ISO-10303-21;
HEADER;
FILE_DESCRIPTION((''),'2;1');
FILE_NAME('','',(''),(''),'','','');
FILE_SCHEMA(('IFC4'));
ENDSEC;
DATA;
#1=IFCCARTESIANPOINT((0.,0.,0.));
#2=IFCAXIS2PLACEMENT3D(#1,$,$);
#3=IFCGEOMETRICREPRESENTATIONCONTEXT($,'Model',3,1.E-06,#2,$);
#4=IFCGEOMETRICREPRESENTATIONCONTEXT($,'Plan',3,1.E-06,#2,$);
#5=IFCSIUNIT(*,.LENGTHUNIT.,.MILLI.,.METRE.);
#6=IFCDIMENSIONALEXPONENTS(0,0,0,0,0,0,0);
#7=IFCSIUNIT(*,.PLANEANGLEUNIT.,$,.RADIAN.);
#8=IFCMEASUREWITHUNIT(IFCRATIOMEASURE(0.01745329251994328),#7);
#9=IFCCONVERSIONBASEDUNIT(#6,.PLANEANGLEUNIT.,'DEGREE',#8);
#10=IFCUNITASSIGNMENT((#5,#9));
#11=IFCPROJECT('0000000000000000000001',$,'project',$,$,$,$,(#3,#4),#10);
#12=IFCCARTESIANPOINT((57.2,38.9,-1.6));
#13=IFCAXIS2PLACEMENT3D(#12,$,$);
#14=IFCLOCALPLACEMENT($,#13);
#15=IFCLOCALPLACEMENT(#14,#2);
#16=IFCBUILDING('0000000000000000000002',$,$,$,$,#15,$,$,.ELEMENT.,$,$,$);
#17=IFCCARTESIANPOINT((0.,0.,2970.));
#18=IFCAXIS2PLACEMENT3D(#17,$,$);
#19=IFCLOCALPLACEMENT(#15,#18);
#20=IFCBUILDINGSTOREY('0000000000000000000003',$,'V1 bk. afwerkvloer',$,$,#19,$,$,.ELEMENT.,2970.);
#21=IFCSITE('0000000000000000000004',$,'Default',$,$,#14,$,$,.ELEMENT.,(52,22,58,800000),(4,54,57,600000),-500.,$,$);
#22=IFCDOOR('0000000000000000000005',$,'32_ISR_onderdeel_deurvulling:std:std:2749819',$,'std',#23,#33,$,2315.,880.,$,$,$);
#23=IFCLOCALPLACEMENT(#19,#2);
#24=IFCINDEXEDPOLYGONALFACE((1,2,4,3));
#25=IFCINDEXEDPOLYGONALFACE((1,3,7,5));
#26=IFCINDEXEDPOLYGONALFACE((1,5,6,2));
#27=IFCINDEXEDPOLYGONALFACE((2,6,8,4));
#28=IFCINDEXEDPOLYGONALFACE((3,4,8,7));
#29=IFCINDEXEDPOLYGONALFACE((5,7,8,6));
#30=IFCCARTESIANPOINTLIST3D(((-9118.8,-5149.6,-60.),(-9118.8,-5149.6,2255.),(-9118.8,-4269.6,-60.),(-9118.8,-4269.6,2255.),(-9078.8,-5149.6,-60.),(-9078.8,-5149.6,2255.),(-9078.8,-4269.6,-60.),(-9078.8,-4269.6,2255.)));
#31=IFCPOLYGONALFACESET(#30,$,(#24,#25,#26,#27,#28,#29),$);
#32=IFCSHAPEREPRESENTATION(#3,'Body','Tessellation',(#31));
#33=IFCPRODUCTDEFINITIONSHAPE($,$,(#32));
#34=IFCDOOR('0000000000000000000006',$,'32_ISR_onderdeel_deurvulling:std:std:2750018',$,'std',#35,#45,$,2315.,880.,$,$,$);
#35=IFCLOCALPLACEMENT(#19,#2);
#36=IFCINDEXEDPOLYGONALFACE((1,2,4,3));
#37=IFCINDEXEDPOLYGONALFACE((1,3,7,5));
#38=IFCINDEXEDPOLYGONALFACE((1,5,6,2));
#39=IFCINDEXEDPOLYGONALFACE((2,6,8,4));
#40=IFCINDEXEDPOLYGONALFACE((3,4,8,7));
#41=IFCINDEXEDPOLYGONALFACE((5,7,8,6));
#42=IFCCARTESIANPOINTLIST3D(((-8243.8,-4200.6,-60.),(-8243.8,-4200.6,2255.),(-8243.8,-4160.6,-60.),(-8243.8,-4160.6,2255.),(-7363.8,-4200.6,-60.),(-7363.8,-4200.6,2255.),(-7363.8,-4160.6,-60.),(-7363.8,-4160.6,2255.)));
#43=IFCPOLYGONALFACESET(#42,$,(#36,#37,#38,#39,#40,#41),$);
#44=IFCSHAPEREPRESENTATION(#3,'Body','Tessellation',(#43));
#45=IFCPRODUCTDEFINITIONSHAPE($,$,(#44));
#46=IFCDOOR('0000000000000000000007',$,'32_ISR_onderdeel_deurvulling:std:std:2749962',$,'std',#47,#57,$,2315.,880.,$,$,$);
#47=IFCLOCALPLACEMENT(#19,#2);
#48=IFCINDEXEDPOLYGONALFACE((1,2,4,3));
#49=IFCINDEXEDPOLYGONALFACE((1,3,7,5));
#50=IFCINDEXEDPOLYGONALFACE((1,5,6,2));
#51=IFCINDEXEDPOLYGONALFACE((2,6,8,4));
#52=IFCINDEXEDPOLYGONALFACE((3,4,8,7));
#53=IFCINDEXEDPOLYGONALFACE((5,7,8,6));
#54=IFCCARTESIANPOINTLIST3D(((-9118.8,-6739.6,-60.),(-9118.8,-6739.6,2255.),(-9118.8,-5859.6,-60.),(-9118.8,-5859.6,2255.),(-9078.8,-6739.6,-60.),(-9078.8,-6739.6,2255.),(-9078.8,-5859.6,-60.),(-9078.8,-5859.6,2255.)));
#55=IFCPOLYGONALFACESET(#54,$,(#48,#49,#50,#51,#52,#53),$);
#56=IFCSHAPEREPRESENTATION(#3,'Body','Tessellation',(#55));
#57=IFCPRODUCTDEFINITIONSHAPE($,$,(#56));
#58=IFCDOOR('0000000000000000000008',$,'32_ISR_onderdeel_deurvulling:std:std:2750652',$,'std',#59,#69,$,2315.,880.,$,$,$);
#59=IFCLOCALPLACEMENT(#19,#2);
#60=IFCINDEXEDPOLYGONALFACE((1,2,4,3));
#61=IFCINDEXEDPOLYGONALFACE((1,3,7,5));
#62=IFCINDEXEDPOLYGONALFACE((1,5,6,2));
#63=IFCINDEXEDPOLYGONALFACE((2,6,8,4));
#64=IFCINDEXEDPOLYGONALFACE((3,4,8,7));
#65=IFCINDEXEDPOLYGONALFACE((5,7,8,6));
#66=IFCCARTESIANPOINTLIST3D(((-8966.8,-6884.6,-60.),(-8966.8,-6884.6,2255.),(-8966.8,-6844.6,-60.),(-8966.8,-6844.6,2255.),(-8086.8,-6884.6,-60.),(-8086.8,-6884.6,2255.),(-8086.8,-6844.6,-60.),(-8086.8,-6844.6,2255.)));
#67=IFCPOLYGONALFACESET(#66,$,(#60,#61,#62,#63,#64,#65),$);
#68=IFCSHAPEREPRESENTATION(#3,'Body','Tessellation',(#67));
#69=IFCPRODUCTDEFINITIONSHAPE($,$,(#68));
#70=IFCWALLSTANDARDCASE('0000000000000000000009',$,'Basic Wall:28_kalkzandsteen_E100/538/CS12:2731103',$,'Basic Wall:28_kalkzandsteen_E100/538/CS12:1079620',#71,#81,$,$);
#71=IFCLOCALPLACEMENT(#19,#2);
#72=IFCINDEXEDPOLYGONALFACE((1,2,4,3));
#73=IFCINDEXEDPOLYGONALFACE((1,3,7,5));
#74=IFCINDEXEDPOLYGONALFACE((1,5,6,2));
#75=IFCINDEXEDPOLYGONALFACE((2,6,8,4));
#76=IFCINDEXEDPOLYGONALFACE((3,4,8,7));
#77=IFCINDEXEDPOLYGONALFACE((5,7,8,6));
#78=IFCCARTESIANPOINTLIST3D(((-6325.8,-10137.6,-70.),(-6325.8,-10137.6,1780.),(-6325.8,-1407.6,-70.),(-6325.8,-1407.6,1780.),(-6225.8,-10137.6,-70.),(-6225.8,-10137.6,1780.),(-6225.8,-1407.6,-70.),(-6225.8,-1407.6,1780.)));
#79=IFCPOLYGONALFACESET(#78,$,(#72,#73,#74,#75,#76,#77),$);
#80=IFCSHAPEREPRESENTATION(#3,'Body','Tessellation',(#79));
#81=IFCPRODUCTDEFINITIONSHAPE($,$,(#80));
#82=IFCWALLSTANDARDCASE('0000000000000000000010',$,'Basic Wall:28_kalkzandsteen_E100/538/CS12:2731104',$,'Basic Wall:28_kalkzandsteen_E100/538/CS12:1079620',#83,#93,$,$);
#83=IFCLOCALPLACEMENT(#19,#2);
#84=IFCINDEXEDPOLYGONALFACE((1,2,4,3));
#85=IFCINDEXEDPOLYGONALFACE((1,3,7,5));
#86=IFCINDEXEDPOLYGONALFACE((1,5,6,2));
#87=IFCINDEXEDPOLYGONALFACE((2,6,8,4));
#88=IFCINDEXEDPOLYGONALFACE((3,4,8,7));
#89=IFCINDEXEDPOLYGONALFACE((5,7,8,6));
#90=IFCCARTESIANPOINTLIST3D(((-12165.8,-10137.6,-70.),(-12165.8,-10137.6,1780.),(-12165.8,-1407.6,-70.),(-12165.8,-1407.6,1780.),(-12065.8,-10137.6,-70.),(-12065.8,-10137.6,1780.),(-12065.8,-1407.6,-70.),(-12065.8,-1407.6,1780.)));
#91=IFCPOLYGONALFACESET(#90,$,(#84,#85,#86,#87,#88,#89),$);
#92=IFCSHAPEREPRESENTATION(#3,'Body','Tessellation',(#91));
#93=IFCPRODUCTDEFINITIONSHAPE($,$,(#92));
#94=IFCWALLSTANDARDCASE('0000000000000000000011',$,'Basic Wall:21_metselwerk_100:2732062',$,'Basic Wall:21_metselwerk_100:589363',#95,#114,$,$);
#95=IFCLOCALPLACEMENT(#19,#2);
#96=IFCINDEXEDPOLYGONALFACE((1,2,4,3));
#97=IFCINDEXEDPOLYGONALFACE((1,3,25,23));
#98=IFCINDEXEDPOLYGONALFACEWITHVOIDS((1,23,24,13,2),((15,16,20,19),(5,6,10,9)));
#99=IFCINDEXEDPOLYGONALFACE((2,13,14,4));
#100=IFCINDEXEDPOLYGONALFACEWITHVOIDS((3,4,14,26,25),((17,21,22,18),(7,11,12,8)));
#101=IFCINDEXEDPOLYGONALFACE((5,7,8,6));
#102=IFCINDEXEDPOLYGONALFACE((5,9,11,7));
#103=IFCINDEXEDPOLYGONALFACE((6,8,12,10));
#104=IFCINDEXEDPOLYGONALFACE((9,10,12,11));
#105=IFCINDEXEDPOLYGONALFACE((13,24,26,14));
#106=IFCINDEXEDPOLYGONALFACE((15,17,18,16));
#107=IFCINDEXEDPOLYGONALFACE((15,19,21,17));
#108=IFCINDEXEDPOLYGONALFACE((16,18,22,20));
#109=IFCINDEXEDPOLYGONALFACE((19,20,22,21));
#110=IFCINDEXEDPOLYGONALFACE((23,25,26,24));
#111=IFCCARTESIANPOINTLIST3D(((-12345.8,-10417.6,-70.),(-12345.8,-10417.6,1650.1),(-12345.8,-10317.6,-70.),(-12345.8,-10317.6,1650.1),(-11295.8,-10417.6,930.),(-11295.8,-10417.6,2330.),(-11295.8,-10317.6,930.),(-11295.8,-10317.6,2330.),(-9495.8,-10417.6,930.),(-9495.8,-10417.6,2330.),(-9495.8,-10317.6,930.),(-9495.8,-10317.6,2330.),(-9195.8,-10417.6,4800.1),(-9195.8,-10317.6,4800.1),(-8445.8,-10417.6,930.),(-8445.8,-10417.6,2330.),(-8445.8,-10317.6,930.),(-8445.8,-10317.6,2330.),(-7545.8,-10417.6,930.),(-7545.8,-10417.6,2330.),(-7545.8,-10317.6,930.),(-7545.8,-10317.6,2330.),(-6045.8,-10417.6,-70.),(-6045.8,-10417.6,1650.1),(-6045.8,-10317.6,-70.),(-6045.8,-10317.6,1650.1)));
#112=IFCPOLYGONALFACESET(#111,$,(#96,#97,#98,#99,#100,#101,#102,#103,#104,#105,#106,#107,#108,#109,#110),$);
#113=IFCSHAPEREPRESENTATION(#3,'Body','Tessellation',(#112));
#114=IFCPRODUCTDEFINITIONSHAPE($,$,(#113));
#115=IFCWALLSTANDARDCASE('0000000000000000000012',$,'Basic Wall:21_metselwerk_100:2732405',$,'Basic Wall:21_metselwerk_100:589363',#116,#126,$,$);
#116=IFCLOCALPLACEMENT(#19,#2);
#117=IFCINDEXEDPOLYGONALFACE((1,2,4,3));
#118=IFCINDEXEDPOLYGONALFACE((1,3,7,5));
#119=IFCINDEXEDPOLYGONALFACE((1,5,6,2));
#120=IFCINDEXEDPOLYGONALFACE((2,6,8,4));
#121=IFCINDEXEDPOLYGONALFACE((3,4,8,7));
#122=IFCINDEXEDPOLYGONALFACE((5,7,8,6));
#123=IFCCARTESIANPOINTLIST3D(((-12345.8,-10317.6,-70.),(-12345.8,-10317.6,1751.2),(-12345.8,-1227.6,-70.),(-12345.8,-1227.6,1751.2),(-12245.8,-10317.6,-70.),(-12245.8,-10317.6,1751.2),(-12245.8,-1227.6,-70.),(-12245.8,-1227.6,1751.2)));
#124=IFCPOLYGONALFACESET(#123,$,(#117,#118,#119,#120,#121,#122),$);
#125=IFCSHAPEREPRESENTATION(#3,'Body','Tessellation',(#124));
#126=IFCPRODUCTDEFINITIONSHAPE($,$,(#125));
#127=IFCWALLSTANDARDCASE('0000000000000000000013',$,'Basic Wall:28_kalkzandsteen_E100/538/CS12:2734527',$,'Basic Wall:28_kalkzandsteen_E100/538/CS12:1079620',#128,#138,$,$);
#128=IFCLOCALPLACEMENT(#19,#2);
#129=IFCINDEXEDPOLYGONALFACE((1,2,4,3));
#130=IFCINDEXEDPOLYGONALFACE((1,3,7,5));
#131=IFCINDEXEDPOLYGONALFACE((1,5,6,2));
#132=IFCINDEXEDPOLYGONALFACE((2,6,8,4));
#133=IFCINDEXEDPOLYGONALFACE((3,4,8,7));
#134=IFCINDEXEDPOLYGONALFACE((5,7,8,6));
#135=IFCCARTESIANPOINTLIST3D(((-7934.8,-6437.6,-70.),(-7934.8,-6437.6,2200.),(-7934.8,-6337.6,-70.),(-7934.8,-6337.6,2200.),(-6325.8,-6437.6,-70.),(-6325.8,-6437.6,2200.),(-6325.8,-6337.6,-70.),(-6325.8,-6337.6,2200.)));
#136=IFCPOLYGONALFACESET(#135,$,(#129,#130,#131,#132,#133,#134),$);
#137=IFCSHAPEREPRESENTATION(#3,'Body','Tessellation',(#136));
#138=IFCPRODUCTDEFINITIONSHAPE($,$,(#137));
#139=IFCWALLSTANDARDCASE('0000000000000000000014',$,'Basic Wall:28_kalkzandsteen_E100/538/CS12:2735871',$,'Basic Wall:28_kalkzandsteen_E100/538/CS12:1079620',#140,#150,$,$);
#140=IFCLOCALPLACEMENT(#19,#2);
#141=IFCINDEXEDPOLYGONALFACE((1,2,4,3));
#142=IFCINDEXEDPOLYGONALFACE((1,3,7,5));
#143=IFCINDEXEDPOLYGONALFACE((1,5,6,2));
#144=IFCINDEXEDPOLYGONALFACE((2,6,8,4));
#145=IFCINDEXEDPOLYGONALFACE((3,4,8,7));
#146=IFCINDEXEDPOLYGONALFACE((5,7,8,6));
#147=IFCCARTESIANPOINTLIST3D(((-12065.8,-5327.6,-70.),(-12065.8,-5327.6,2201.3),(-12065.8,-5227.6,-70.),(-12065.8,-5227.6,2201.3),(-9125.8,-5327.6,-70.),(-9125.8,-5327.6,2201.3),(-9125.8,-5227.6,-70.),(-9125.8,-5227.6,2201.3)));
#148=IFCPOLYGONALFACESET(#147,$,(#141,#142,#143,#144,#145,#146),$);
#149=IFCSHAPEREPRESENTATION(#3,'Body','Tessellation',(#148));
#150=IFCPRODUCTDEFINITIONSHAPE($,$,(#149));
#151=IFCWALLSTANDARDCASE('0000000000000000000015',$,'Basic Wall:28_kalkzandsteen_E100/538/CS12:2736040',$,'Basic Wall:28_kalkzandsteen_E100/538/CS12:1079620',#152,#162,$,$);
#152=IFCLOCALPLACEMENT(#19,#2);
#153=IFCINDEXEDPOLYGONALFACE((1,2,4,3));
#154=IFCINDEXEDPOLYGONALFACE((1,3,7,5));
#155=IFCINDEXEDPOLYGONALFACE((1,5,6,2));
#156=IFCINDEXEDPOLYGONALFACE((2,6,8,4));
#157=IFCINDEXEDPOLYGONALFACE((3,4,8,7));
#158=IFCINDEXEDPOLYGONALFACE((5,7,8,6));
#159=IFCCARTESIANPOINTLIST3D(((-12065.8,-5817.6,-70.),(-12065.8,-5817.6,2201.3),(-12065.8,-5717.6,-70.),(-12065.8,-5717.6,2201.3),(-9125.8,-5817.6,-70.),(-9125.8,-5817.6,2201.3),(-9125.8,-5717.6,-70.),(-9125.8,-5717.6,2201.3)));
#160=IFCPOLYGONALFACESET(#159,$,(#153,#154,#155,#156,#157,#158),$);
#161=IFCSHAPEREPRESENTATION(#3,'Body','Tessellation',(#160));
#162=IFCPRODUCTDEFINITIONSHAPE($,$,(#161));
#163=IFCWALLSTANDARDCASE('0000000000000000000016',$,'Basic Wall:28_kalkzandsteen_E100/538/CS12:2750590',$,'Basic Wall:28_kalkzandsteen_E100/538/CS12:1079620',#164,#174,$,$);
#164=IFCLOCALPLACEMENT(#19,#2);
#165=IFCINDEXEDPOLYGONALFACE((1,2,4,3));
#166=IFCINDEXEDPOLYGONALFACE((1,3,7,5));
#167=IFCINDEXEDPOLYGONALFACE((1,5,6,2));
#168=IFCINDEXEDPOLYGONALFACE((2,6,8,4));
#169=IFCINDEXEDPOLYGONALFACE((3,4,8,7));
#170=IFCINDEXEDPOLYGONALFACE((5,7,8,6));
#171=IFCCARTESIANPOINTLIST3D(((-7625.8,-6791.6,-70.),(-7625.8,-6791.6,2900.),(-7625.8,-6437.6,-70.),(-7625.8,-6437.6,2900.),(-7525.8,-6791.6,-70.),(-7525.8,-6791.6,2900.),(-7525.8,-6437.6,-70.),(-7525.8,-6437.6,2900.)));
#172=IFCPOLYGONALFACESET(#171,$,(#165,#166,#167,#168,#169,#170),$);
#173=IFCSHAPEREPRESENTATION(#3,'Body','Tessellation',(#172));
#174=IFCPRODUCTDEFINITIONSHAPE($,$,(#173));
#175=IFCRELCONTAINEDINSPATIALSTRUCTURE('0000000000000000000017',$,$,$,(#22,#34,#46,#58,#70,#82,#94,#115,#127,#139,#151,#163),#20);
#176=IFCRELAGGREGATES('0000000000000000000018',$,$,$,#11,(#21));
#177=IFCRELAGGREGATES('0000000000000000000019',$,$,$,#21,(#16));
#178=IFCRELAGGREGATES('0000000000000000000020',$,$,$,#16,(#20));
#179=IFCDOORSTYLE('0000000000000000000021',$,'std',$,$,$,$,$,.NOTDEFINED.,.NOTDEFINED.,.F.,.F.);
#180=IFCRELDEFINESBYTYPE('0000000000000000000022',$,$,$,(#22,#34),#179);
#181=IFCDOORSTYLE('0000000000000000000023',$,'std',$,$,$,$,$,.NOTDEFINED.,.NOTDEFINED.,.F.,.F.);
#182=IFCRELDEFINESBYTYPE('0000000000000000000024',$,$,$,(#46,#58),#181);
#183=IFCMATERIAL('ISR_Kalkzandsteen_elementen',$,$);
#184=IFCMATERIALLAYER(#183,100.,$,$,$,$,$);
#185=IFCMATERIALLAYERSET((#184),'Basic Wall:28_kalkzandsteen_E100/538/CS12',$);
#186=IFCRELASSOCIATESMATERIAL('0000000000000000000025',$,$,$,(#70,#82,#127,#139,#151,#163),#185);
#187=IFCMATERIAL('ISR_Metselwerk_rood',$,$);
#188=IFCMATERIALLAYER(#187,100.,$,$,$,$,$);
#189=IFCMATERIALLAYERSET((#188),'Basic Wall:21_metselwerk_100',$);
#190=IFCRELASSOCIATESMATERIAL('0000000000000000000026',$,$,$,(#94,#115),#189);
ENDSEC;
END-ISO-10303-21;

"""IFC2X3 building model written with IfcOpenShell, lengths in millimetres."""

from ifc_helpers import new_model, entity, si_unit, converted_unit, frame, frame_2d, origin, origin_2d_with_axis, place, context, project, spatial, polyline, rectangle, extrude, clip, bounded_halfspace, source, transform, mapped, material, layer, layer_set, layer_usage, type_object, type_shapes, element, save


model = new_model("IFC2X3")

# Units and contexts
model_context = context("Model", 3, precision=1e-06, world=origin())
plan_context = context("Plan", 3, precision=1e-06, world=origin())
ifc_project = project(units=[si_unit("LENGTHUNIT", "METRE", prefix="MILLI"), converted_unit("PLANEANGLEUNIT", "DEGREE", entity("IfcRatioMeasure", 0.01745329251994328), si_unit("PLANEANGLEUNIT", "RADIAN"), dimensions=[0, 0, 0, 0, 0, 0, 0])], contexts=[model_context, plan_context])

# Site, building, storey
site_placement = place(None, frame((57.2, 38.9, -1.6)))
site = spatial("IfcSite", under=ifc_project, at=site_placement, Name="Default", CompositionType="ELEMENT", RefLatitude=(52, 22, 58, 800000), RefLongitude=(4, 54, 57, 600000), RefElevation=-500.0)
building_placement = place(site_placement, origin())
building = spatial("IfcBuilding", under=site, at=building_placement, CompositionType="ELEMENT")
storey_placement = place(building_placement, frame((0.0, 0.0, 2970.0)))
storey = spatial("IfcBuildingStorey", under=building, at=storey_placement, Name="V1 bk. afwerkvloer", CompositionType="ELEMENT", Elevation=2970.0)

# Doors
door_style_1 = type_object("IfcDoorStyle", Name="std", ConstructionType="NOTDEFINED", OperationType="NOTDEFINED", ParameterTakesPrecedence=False, Sizeable=False)
shared_shape_1 = source(origin(), model_context, "Body", "SweptSolid", [
    extrude(rectangle(XDim=880.0, YDim=40.0, at=origin_2d_with_axis()), frame((0.0, 34.0, 0.0)), (0.0, 0.0, 1.0), 2315.0),
])
type_shapes(door_style_1, [shared_shape_1])
door_1_placement = place(storey_placement, frame((-9132.8, -4709.6, -60.0), z_axis=(0.0, 0.0, 1.0), x_axis=(0.0, -1.0, 0.0)))
element("IfcDoor", 1, at=door_1_placement, inside=storey, type_object=door_style_1, Name="32_ISR_onderdeel_deurvulling:std:std:2749819", ObjectType="std", OverallHeight=2315.0, OverallWidth=880.0, context=model_context, shape_type="MappedRepresentation", body=[
    mapped(shared_shape_1, transform((0.0, 0.0, 0.0), scale=1.0)),
])
door_2_placement = place(storey_placement, frame((-7803.8, -4214.6, -60.0)))
element("IfcDoor", 2, at=door_2_placement, inside=storey, type_object=door_style_1, Name="32_ISR_onderdeel_deurvulling:std:std:2750018", ObjectType="std", OverallHeight=2315.0, OverallWidth=880.0, context=model_context, shape_type="MappedRepresentation", body=[
    mapped(shared_shape_1, transform((0.0, 0.0, 0.0), scale=1.0)),
])
door_style_2 = type_object("IfcDoorStyle", Name="std", ConstructionType="NOTDEFINED", OperationType="NOTDEFINED", ParameterTakesPrecedence=False, Sizeable=False)
shared_shape_2 = source(origin(), model_context, "Body", "SweptSolid", [
    extrude(rectangle(XDim=40.0, YDim=880.0, at=origin_2d_with_axis()), frame((0.0, -34.0, 0.0), z_axis=(0.0, 0.0, 1.0), x_axis=(0.0, -1.0, 0.0)), (0.0, 0.0, 1.0), 2315.0),
])
type_shapes(door_style_2, [shared_shape_2])
for number, where, z_axis, x_axis, name in (
    (3, (-9132.8, -6299.6, -60.0), (0.0, 0.0, 1.0), (0.0, 1.0, 0.0), "32_ISR_onderdeel_deurvulling:std:std:2749962"),
    (4, (-8526.8, -6898.6, -60.0), (0.0, 0.0, 1.0), (-1.0, 0.0, 0.0), "32_ISR_onderdeel_deurvulling:std:std:2750652"),
):
    element("IfcDoor", number, at=place(storey_placement, frame(where, z_axis=z_axis, x_axis=x_axis)), inside=storey, type_object=door_style_2, Name=name, ObjectType="std", OverallHeight=2315.0, OverallWidth=880.0, context=model_context, shape_type="MappedRepresentation", body=[
        mapped(shared_shape_2, transform((0.0, 0.0, 0.0), scale=1.0)),
    ])

# Shared definitions
ifc_material_1 = material(Name="ISR_Kalkzandsteen_elementen")
ifc_layer_1 = layer(ifc_material_1, 100.0)
ifc_layer_set_1 = layer_set([ifc_layer_1], Name="Basic Wall:28_kalkzandsteen_E100/538/CS12")

# Walls
ifc_layer_usage_1 = layer_usage(ifc_layer_set_1, "AXIS2", "NEGATIVE", 50.0)
wall_1_placement = place(storey_placement, frame((-6275.8, -10137.6, -70.0), z_axis=(0.0, 0.0, 1.0), x_axis=(0.0, 1.0, 0.0)))
element("IfcWallStandardCase", 5, at=wall_1_placement, inside=storey, material=ifc_layer_usage_1, Name="Basic Wall:28_kalkzandsteen_E100/538/CS12:2731103", ObjectType="Basic Wall:28_kalkzandsteen_E100/538/CS12:1079620", context=model_context, shape_type="SweptSolid", body=[
    extrude(rectangle(XDim=8730.0, YDim=100.0, at=frame_2d((4365.0, 0.0), x_axis=(-1.0, 0.0))), origin(), (0.0, 0.0, 1.0), 1850.0),
])
ifc_layer_usage_2 = layer_usage(ifc_layer_set_1, "AXIS2", "NEGATIVE", 50.0)
wall_2_placement = place(storey_placement, frame((-12115.8, -1407.6, -70.0), z_axis=(0.0, 0.0, 1.0), x_axis=(0.0, -1.0, 0.0)))
element("IfcWallStandardCase", 6, at=wall_2_placement, inside=storey, material=ifc_layer_usage_2, Name="Basic Wall:28_kalkzandsteen_E100/538/CS12:2731104", ObjectType="Basic Wall:28_kalkzandsteen_E100/538/CS12:1079620", context=model_context, shape_type="SweptSolid", body=[
    extrude(rectangle(XDim=8730.0, YDim=100.0, at=frame_2d((4365.0, 0.0), x_axis=(-1.0, 0.0))), origin(), (0.0, 0.0, 1.0), 1850.0),
])

# Wall, openings
ifc_material_2 = material(Name="ISR_Metselwerk_rood")
ifc_layer_2 = layer(ifc_material_2, 100.0)
ifc_layer_set_2 = layer_set([ifc_layer_2], Name="Basic Wall:21_metselwerk_100")
ifc_layer_usage_3 = layer_usage(ifc_layer_set_2, "AXIS2", "NEGATIVE", 50.0)
wall_3_placement = place(storey_placement, frame((-12345.8, -10367.6, -70.0)))
wall_3 = element("IfcWallStandardCase", 7, at=wall_3_placement, inside=storey, material=ifc_layer_usage_3, Name="Basic Wall:21_metselwerk_100:2732062", ObjectType="Basic Wall:21_metselwerk_100:589363", context=model_context, shape_type="Clipping", body=[
    clip(clip(extrude(rectangle(XDim=6300.0, YDim=100.0, at=frame_2d((3150.0, 0.0), x_axis=(-1.0, 0.0))), origin(), (0.0, 0.0, 1.0), 4870.1), bounded_halfspace(frame((0.0, 50.0, 1720.1), z_axis=(-0.707107, 0.0, 0.707107), x_axis=(0.0, -1.0, 0.0)), False, frame((0.0, 50.0, 1720.1)), polyline([(0.0, 0.0), (0.0, -100.0), (3150.0, -100.0), (3150.0, 0.0), (0.0, 0.0)]))), bounded_halfspace(frame((6300.0, -50.0, 1720.1), z_axis=(0.707107, 0.0, 0.707107), x_axis=(0.0, 1.0, 0.0)), False, frame((6300.0, -50.0, 1720.1)), polyline([(0.0, 0.0), (0.0, 100.0), (-3150.0, 100.0), (-3150.0, 0.0), (0.0, 0.0)]))),
])
opening_1_placement = place(wall_3_placement, origin())
element("IfcOpeningElement", 8, at=opening_1_placement, cuts=wall_3, ObjectType="Opening", context=model_context, shape_type="SweptSolid", body=[
    extrude(rectangle(XDim=1400.0, YDim=900.0, at=origin_2d_with_axis()), frame((4350.0, -202.4, 1700.0), z_axis=(0.0, 1.0, 0.0), x_axis=(0.0, 0.0, 1.0)), (0.0, 0.0, 1.0), 404.8),
])
opening_2_placement = place(wall_3_placement, origin())
element("IfcOpeningElement", 9, at=opening_2_placement, cuts=wall_3, ObjectType="Opening", context=model_context, shape_type="SweptSolid", body=[
    extrude(rectangle(XDim=1400.0, YDim=1800.0, at=origin_2d_with_axis()), frame((1950.0, -202.4, 1700.0), z_axis=(0.0, 1.0, 0.0), x_axis=(0.0, 0.0, 1.0)), (0.0, 0.0, 1.0), 404.8),
])

# Wall
ifc_layer_usage_4 = layer_usage(ifc_layer_set_2, "AXIS2", "NEGATIVE", 50.0)
wall_4_placement = place(storey_placement, frame((-12295.8, -10317.6, -70.0), z_axis=(0.0, 0.0, 1.0), x_axis=(0.0, 1.0, 0.0)))
element("IfcWallStandardCase", 10, at=wall_4_placement, inside=storey, material=ifc_layer_usage_4, Name="Basic Wall:21_metselwerk_100:2732405", ObjectType="Basic Wall:21_metselwerk_100:589363", context=model_context, shape_type="SweptSolid", body=[
    extrude(rectangle(XDim=9090.0, YDim=100.0, at=frame_2d((4545.0, 0.0), x_axis=(-1.0, 0.0))), origin(), (0.0, 0.0, 1.0), 1821.2),
])

# Wall
ifc_layer_usage_5 = layer_usage(ifc_layer_set_1, "AXIS2", "POSITIVE", -50.0)
wall_5_placement = place(storey_placement, frame((-7934.8, -6387.6, -70.0)))
element("IfcWallStandardCase", 11, at=wall_5_placement, inside=storey, material=ifc_layer_usage_5, Name="Basic Wall:28_kalkzandsteen_E100/538/CS12:2734527", ObjectType="Basic Wall:28_kalkzandsteen_E100/538/CS12:1079620", context=model_context, shape_type="SweptSolid", body=[
    extrude(rectangle(XDim=1609.0, YDim=100.0, at=frame_2d((804.5, 0.0), x_axis=(-1.0, 0.0))), origin(), (0.0, 0.0, 1.0), 2270.0),
])

# Walls
ifc_layer_usage_6 = layer_usage(ifc_layer_set_1, "AXIS2", "POSITIVE", -50.0)
wall_6_placement = place(storey_placement, frame((-12065.8, -5277.6, -70.0)))
element("IfcWallStandardCase", 12, at=wall_6_placement, inside=storey, material=ifc_layer_usage_6, Name="Basic Wall:28_kalkzandsteen_E100/538/CS12:2735871", ObjectType="Basic Wall:28_kalkzandsteen_E100/538/CS12:1079620", context=model_context, shape_type="SweptSolid", body=[
    extrude(rectangle(XDim=2940.0, YDim=100.0, at=frame_2d((1470.0, 0.0), x_axis=(-1.0, 0.0))), origin(), (0.0, 0.0, 1.0), 2271.3),
])
ifc_layer_usage_7 = layer_usage(ifc_layer_set_1, "AXIS2", "POSITIVE", -50.0)
wall_7_placement = place(storey_placement, frame((-12065.8, -5767.6, -70.0)))
element("IfcWallStandardCase", 13, at=wall_7_placement, inside=storey, material=ifc_layer_usage_7, Name="Basic Wall:28_kalkzandsteen_E100/538/CS12:2736040", ObjectType="Basic Wall:28_kalkzandsteen_E100/538/CS12:1079620", context=model_context, shape_type="SweptSolid", body=[
    extrude(rectangle(XDim=2940.0, YDim=100.0, at=frame_2d((1470.0, 0.0), x_axis=(-1.0, 0.0))), origin(), (0.0, 0.0, 1.0), 2271.3),
])

# Wall
ifc_layer_usage_8 = layer_usage(ifc_layer_set_1, "AXIS2", "NEGATIVE", 50.0)
wall_8_placement = place(storey_placement, frame((-7575.8, -6437.6, -70.0), z_axis=(0.0, 0.0, 1.0), x_axis=(0.0, -1.0, 0.0)))
element("IfcWallStandardCase", 14, at=wall_8_placement, inside=storey, material=ifc_layer_usage_8, Name="Basic Wall:28_kalkzandsteen_E100/538/CS12:2750590", ObjectType="Basic Wall:28_kalkzandsteen_E100/538/CS12:1079620", context=model_context, shape_type="SweptSolid", body=[
    extrude(rectangle(XDim=354.0, YDim=100.0, at=frame_2d((177.0, 0.0), x_axis=(-1.0, 0.0))), origin(), (0.0, 0.0, 1.0), 2970.0),
])

save(model, "model.ifc")
